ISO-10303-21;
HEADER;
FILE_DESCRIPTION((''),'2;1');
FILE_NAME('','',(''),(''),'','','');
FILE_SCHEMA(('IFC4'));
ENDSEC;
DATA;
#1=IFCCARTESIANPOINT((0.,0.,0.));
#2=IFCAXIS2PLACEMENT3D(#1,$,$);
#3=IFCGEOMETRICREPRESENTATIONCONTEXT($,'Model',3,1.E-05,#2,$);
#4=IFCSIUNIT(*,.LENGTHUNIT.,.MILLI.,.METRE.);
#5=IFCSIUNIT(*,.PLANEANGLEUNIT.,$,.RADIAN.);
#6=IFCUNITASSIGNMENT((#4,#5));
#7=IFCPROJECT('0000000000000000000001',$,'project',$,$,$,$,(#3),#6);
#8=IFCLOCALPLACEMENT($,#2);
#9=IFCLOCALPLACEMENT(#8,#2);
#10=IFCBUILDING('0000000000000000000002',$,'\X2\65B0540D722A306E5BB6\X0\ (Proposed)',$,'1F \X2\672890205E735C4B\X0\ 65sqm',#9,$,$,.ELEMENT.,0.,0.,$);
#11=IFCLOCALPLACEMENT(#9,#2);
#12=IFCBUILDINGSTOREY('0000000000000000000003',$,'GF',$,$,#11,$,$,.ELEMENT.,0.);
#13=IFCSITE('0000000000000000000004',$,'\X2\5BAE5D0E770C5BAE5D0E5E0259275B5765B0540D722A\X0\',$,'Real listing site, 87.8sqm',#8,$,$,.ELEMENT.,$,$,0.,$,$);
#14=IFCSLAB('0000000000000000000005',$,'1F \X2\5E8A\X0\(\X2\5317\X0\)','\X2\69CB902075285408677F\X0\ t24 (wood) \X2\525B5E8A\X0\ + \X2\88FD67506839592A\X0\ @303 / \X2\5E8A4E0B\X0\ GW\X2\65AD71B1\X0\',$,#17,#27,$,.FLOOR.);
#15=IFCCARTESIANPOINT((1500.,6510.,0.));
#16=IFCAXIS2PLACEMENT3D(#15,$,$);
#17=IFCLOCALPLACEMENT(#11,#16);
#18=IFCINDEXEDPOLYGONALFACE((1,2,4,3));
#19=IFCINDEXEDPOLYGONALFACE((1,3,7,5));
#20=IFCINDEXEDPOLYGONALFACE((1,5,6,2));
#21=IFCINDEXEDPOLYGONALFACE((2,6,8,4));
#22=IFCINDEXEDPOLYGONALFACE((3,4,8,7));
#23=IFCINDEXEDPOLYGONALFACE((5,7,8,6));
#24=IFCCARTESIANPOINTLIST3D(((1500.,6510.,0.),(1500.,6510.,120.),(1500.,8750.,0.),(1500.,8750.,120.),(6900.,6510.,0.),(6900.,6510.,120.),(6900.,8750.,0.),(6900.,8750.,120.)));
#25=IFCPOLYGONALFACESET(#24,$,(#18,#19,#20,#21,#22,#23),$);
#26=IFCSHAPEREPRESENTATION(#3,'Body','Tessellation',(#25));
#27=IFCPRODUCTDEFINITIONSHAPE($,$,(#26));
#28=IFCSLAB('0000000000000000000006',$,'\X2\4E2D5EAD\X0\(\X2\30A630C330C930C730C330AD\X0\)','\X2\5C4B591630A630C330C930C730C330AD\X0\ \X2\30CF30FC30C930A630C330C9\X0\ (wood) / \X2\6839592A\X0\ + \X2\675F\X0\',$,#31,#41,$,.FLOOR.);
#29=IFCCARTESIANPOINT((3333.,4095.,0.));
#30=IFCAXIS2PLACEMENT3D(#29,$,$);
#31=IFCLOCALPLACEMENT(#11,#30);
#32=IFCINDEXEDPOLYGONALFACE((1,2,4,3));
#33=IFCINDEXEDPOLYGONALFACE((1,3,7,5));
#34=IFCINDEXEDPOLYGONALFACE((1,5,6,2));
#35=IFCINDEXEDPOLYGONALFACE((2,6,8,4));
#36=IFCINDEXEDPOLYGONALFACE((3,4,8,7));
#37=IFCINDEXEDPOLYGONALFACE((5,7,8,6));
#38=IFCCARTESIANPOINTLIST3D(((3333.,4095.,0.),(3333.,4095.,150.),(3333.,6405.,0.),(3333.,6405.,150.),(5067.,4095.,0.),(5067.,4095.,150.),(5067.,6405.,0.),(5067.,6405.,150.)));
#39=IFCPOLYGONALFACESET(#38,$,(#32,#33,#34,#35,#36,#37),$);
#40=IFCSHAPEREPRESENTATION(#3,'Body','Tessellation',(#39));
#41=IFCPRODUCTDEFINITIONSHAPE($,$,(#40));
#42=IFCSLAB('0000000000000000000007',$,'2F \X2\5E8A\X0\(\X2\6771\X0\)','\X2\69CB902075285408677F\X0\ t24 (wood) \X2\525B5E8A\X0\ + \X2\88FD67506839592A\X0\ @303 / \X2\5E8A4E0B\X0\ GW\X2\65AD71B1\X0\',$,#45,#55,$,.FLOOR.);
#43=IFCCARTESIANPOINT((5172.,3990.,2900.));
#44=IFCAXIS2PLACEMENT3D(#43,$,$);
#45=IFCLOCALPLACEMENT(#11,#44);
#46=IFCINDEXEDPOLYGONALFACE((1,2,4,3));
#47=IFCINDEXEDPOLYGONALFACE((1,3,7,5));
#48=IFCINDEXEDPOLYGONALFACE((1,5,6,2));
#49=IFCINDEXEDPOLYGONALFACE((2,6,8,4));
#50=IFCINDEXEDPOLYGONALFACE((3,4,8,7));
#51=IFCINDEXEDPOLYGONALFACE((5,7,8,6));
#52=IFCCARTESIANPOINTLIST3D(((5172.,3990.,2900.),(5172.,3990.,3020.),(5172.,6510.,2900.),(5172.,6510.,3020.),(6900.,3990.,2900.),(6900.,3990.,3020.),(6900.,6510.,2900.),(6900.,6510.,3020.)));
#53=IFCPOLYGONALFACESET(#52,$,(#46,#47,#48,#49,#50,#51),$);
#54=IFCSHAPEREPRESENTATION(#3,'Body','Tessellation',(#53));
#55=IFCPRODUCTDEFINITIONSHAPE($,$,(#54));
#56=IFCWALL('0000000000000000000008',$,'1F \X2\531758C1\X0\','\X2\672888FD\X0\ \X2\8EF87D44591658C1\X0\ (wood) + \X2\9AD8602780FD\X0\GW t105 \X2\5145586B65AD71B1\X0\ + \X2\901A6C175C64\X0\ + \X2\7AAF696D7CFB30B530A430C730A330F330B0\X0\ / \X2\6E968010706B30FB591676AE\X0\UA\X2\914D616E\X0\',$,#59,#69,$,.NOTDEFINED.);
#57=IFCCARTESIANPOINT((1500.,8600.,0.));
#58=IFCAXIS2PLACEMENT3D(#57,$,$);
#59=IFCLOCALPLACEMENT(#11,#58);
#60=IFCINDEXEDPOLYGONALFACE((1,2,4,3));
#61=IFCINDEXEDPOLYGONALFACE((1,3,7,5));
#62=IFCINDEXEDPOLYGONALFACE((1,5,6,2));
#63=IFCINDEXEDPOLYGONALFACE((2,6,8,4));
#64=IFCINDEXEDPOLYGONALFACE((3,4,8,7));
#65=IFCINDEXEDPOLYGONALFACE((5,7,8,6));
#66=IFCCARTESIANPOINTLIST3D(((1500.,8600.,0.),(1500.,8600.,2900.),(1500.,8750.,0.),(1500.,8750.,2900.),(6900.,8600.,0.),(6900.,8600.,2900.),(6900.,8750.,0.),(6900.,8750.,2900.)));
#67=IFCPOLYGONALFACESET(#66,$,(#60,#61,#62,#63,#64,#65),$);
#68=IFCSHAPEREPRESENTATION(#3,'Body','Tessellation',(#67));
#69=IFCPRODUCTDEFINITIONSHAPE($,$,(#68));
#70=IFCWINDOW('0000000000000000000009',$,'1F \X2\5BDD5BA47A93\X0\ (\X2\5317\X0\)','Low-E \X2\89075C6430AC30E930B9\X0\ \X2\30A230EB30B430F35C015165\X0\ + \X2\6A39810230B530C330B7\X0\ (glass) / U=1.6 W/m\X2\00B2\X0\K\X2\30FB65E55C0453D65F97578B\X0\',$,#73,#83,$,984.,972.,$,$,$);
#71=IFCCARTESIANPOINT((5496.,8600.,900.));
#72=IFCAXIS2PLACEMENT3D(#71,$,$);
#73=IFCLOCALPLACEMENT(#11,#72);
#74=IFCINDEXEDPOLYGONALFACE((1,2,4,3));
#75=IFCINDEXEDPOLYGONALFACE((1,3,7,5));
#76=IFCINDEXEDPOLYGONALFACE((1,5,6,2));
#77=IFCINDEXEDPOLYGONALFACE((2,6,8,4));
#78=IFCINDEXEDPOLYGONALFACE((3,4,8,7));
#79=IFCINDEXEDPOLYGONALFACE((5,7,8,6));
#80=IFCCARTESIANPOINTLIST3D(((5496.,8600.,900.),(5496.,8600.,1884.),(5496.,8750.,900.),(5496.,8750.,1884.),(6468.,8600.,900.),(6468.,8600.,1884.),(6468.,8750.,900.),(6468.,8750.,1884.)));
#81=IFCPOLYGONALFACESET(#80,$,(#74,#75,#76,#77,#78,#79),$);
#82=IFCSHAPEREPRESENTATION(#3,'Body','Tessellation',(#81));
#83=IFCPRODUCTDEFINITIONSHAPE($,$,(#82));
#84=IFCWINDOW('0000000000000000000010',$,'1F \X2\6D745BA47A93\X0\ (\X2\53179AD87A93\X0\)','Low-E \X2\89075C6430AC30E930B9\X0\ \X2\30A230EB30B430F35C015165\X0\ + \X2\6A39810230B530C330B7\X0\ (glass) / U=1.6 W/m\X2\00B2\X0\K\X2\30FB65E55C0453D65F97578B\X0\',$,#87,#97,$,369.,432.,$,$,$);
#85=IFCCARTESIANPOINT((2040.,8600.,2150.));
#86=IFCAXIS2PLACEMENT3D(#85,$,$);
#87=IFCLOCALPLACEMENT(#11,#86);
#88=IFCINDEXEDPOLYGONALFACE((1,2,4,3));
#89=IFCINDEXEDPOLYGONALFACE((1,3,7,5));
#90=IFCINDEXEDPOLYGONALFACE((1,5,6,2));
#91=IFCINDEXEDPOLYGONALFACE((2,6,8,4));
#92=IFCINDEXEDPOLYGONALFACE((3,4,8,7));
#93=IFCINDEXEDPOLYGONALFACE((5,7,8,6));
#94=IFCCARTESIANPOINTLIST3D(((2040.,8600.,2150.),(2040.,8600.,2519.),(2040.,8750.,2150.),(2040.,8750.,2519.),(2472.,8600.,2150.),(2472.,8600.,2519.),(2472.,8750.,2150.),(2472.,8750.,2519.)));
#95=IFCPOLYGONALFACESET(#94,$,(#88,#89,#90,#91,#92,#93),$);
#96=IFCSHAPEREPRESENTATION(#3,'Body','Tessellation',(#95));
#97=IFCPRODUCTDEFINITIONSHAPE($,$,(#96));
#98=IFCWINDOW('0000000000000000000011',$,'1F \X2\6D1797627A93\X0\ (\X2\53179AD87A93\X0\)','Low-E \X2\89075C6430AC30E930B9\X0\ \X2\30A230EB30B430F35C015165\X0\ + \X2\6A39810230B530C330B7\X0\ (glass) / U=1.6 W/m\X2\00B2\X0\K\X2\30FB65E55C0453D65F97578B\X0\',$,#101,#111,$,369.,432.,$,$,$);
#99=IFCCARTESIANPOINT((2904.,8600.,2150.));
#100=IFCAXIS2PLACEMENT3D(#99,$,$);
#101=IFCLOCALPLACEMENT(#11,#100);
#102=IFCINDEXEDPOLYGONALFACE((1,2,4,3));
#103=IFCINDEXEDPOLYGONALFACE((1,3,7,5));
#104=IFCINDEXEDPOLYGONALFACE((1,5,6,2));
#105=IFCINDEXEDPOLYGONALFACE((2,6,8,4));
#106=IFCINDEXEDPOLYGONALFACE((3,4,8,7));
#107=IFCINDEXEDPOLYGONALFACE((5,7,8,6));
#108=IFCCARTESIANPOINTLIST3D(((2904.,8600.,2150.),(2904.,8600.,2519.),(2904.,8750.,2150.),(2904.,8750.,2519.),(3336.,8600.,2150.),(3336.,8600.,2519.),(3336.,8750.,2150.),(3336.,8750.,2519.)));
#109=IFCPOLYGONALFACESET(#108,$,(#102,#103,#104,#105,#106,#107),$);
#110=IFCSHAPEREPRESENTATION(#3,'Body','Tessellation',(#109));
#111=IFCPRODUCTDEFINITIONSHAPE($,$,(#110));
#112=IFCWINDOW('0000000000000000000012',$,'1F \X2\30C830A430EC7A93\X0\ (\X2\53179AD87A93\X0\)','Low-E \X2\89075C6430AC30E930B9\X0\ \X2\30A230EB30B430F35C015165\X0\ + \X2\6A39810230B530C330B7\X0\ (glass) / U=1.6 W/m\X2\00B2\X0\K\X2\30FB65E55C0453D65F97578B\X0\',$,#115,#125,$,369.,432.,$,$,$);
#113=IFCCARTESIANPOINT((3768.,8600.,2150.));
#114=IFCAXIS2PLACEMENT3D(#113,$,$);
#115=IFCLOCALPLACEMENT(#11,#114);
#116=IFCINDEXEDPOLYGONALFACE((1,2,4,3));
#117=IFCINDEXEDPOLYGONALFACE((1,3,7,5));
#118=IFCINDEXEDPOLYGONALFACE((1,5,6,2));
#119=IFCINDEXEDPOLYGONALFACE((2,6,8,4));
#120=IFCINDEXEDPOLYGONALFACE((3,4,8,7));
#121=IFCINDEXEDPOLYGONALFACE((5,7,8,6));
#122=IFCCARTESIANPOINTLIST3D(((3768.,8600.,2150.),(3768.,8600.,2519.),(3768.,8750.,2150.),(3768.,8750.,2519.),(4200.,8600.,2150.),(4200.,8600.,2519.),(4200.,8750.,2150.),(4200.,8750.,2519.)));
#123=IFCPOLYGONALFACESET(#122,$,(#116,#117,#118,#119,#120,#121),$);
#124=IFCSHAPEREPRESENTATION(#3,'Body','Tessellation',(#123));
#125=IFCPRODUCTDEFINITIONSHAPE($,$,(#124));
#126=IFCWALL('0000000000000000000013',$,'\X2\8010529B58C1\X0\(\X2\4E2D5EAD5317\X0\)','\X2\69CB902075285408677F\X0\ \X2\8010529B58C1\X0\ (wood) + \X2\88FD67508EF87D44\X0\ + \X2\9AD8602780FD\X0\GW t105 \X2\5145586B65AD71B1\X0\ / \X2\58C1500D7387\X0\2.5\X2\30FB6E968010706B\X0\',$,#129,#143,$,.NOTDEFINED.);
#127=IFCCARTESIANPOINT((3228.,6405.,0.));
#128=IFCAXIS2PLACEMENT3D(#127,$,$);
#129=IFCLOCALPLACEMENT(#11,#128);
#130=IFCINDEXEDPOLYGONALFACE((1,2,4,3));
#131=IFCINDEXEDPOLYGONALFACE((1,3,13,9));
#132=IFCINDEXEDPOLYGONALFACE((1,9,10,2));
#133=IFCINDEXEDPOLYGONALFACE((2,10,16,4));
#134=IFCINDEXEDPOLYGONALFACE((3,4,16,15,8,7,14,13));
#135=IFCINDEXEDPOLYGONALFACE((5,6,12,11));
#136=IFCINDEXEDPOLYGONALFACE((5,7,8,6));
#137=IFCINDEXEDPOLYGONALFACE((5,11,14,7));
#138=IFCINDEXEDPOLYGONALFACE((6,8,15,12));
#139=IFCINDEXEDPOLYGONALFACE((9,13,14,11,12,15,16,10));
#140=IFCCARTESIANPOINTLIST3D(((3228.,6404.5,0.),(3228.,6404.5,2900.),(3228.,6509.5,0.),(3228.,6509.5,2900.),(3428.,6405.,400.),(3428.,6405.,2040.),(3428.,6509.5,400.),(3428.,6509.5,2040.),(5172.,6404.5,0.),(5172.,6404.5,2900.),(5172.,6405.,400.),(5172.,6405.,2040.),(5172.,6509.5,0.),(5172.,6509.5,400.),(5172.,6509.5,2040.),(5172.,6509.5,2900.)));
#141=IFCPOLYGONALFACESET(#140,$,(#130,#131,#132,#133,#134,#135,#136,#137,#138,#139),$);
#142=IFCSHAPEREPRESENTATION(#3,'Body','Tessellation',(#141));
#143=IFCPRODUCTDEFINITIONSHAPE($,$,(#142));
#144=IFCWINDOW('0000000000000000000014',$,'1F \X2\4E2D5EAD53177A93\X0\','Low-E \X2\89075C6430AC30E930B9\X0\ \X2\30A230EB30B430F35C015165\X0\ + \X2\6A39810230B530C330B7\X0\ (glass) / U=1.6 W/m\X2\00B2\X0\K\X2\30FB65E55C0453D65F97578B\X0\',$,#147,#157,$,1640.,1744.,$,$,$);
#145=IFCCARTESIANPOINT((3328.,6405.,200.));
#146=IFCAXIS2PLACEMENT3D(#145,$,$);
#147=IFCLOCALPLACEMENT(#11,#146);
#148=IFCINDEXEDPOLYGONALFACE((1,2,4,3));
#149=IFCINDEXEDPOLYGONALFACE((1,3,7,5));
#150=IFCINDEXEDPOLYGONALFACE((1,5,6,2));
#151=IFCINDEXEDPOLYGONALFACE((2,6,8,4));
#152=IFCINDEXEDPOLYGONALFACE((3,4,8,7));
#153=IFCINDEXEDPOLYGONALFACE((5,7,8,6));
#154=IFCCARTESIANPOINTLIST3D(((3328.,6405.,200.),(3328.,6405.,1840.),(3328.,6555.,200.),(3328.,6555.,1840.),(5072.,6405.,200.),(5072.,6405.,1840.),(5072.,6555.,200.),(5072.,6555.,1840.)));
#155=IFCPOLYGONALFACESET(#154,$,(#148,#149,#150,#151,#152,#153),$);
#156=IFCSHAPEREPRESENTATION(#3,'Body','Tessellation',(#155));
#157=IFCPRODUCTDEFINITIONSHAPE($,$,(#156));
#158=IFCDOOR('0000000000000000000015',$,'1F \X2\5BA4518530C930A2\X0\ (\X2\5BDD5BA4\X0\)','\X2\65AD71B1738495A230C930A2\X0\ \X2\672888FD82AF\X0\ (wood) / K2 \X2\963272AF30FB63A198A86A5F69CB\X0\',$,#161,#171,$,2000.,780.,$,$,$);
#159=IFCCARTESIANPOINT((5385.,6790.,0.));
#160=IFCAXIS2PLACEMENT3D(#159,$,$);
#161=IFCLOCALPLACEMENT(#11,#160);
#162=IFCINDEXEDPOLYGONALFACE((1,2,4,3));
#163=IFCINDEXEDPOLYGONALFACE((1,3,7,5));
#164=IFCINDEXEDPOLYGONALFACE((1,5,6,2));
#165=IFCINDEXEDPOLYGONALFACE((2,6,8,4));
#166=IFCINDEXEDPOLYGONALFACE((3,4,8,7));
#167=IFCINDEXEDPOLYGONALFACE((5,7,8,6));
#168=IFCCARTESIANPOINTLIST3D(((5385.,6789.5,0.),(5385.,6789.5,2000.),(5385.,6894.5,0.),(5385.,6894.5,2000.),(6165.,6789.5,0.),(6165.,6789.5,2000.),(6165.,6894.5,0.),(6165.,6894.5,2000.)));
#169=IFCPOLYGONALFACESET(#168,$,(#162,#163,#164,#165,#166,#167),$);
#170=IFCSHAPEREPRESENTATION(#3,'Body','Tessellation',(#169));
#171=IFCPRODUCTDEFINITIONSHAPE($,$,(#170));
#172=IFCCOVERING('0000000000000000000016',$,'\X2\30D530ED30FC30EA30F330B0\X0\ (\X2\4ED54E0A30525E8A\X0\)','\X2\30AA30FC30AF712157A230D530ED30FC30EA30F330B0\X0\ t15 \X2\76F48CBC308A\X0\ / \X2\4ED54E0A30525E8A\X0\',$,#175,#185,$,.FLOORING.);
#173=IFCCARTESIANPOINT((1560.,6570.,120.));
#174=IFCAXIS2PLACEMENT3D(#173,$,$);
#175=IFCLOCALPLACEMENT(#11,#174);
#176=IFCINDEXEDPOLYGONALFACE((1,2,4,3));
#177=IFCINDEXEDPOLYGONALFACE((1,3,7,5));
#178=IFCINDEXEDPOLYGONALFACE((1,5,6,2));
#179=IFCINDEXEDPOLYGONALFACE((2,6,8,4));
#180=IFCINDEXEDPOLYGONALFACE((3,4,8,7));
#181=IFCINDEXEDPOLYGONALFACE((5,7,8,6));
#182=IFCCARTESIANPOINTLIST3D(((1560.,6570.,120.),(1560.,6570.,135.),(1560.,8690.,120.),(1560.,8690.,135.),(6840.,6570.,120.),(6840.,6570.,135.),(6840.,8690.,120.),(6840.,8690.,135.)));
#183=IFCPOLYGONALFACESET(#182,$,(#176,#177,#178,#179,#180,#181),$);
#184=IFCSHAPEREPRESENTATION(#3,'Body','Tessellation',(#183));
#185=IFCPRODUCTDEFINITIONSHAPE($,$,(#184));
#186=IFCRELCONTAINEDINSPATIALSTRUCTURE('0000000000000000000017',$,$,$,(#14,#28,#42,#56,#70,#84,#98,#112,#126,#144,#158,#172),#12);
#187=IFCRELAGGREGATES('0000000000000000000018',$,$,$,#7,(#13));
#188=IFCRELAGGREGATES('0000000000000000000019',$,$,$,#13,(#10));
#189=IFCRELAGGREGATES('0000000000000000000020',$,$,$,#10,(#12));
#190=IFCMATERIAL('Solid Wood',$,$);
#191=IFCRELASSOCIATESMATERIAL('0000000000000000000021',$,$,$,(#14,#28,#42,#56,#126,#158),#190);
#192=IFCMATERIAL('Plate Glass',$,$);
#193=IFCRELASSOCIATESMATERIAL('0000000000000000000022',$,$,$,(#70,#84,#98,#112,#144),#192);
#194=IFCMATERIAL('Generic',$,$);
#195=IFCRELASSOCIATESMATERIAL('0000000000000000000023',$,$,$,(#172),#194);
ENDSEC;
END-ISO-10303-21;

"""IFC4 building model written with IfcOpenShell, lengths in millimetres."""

from ifc_helpers import new_model, si_unit, frame, frame_2d, origin, place, context, project, spatial, rectangle, extrude, material, element, fill, save


model = new_model("IFC4")

# Units and contexts
model_context = context("Model", 3, precision=1e-05, world=origin())
ifc_project = project(units=[si_unit("LENGTHUNIT", "METRE", prefix="MILLI"), si_unit("PLANEANGLEUNIT", "RADIAN")], contexts=[model_context])

# Site, building, storey
site_placement = place(None, origin())
site = spatial("IfcSite", under=ifc_project, at=site_placement, Name="宮崎県宮崎市大字新名爪", ObjectType="Real listing site, 87.8sqm", CompositionType="ELEMENT", RefElevation=0.0)
building_placement = place(site_placement, origin())
building = spatial("IfcBuilding", under=site, at=building_placement, Name="新名爪の家 (Proposed)", ObjectType="1F 木造平屋 65sqm", CompositionType="ELEMENT", ElevationOfRefHeight=0.0, ElevationOfTerrain=0.0)
storey_placement = place(building_placement, origin())
storey = spatial("IfcBuildingStorey", under=building, at=storey_placement, Name="GF", CompositionType="ELEMENT", Elevation=0.0)

# Slabs
ifc_material_1 = material(Name="Solid Wood")
slab_1_placement = place(storey_placement, frame((1500.0, 6510.0, 0.0)))
element("IfcSlab", 1, at=slab_1_placement, inside=storey, material=ifc_material_1, Name="1F 床(北)", Description="構造用合板 t24 (wood) 剛床 + 製材根太 @303 / 床下 GW断熱", PredefinedType="FLOOR", context=model_context, shape_type="SweptSolid", body=[
    extrude(rectangle(XDim=5400.0, YDim=2240.0, at=frame_2d((2700.0, 1120.0))), frame((1500.0, 6510.0, 0.0)), (0.0, 0.0, 1.0), 120.0),
])
slab_2_placement = place(storey_placement, frame((3333.0, 4095.0, 0.0)))
element("IfcSlab", 2, at=slab_2_placement, inside=storey, material=ifc_material_1, Name="中庭(ウッドデッキ)", Description="屋外ウッドデッキ ハードウッド (wood) / 根太 + 束", PredefinedType="FLOOR", context=model_context, shape_type="SweptSolid", body=[
    extrude(rectangle(XDim=1734.0, YDim=2310.0, at=frame_2d((867.0, 1155.0))), frame((3333.0, 4095.0, 0.0)), (0.0, 0.0, 1.0), 150.0),
])
slab_3_placement = place(storey_placement, frame((5172.0, 3990.0, 2900.0)))
element("IfcSlab", 3, at=slab_3_placement, inside=storey, material=ifc_material_1, Name="2F 床(東)", Description="構造用合板 t24 (wood) 剛床 + 製材根太 @303 / 床下 GW断熱", PredefinedType="FLOOR", context=model_context, shape_type="SweptSolid", body=[
    extrude(rectangle(XDim=1728.0, YDim=2520.0, at=frame_2d((864.0, 1260.0))), frame((5172.0, 3990.0, 2900.0)), (0.0, 0.0, 1.0), 120.0),
])

# Wall, openings, windows
wall_1_placement = place(storey_placement, frame((1500.0, 8600.0, 0.0)))
wall_1 = element("IfcWall", 4, at=wall_1_placement, inside=storey, material=ifc_material_1, Name="1F 北壁", Description="木製 軸組外壁 (wood) + 高性能GW t105 充填断熱 + 通気層 + 窯業系サイディング / 準耐火・外皮UA配慮", PredefinedType="NOTDEFINED", context=model_context, shape_type="SweptSolid", body=[
    extrude(rectangle(XDim=5400.0, YDim=150.0, at=frame_2d((2700.0, 75.0))), frame((1500.0, 8600.0, 0.0)), (0.0, 0.0, 1.0), 2900.0),
])
opening_1_placement = place(storey_placement, frame((5496.0, 8600.0, 900.0)))
opening_1 = element("IfcOpeningElement", 5, at=opening_1_placement, cuts=wall_1, PredefinedType="NOTDEFINED", context=model_context, shape_type="SweptSolid", body=[
    extrude(rectangle(XDim=972.0, YDim=150.0, at=frame_2d((486.0, 75.0))), frame((5496.0, 8600.0, 900.0)), (0.0, 0.0, 1.0), 984.0),
])
opening_2_placement = place(storey_placement, frame((2040.0, 8600.0, 2150.0)))
opening_2 = element("IfcOpeningElement", 6, at=opening_2_placement, cuts=wall_1, PredefinedType="NOTDEFINED", context=model_context, shape_type="SweptSolid", body=[
    extrude(rectangle(XDim=432.0, YDim=150.0, at=frame_2d((216.0, 75.0))), frame((2040.0, 8600.0, 2150.0)), (0.0, 0.0, 1.0), 369.0),
])
opening_3_placement = place(storey_placement, frame((2904.0, 8600.0, 2150.0)))
opening_3 = element("IfcOpeningElement", 7, at=opening_3_placement, cuts=wall_1, PredefinedType="NOTDEFINED", context=model_context, shape_type="SweptSolid", body=[
    extrude(rectangle(XDim=432.0, YDim=150.0, at=frame_2d((216.0, 75.0))), frame((2904.0, 8600.0, 2150.0)), (0.0, 0.0, 1.0), 369.0),
])
opening_4_placement = place(storey_placement, frame((3768.0, 8600.0, 2150.0)))
opening_4 = element("IfcOpeningElement", 8, at=opening_4_placement, cuts=wall_1, PredefinedType="NOTDEFINED", context=model_context, shape_type="SweptSolid", body=[
    extrude(rectangle(XDim=432.0, YDim=150.0, at=frame_2d((216.0, 75.0))), frame((3768.0, 8600.0, 2150.0)), (0.0, 0.0, 1.0), 369.0),
])
ifc_material_2 = material(Name="Plate Glass")
window_1_placement = place(storey_placement, frame((5496.0, 8600.0, 900.0)))
window_1 = element("IfcWindow", 9, at=window_1_placement, inside=storey, material=ifc_material_2, Name="1F 寝室窓 (北)", Description="Low-E 複層ガラス アルゴン封入 + 樹脂サッシ (glass) / U=1.6 W/m²K・日射取得型", OverallHeight=984.0, OverallWidth=972.0, context=model_context, shape_type="SweptSolid", body=[
    extrude(rectangle(XDim=972.0, YDim=150.0, at=frame_2d((486.0, 75.0))), frame((5496.0, 8600.0, 900.0)), (0.0, 0.0, 1.0), 984.0),
])
fill(opening_1, window_1)
window_2_placement = place(storey_placement, frame((2040.0, 8600.0, 2150.0)))
window_2 = element("IfcWindow", 10, at=window_2_placement, inside=storey, material=ifc_material_2, Name="1F 浴室窓 (北高窓)", Description="Low-E 複層ガラス アルゴン封入 + 樹脂サッシ (glass) / U=1.6 W/m²K・日射取得型", OverallHeight=369.0, OverallWidth=432.0, context=model_context, shape_type="SweptSolid", body=[
    extrude(rectangle(XDim=432.0, YDim=150.0, at=frame_2d((216.0, 75.0))), frame((2040.0, 8600.0, 2150.0)), (0.0, 0.0, 1.0), 369.0),
])
fill(opening_2, window_2)
window_3_placement = place(storey_placement, frame((2904.0, 8600.0, 2150.0)))
window_3 = element("IfcWindow", 11, at=window_3_placement, inside=storey, material=ifc_material_2, Name="1F 洗面窓 (北高窓)", Description="Low-E 複層ガラス アルゴン封入 + 樹脂サッシ (glass) / U=1.6 W/m²K・日射取得型", OverallHeight=369.0, OverallWidth=432.0, context=model_context, shape_type="SweptSolid", body=[
    extrude(rectangle(XDim=432.0, YDim=150.0, at=frame_2d((216.0, 75.0))), frame((2904.0, 8600.0, 2150.0)), (0.0, 0.0, 1.0), 369.0),
])
fill(opening_3, window_3)
window_4_placement = place(storey_placement, frame((3768.0, 8600.0, 2150.0)))
window_4 = element("IfcWindow", 12, at=window_4_placement, inside=storey, material=ifc_material_2, Name="1F トイレ窓 (北高窓)", Description="Low-E 複層ガラス アルゴン封入 + 樹脂サッシ (glass) / U=1.6 W/m²K・日射取得型", OverallHeight=369.0, OverallWidth=432.0, context=model_context, shape_type="SweptSolid", body=[
    extrude(rectangle(XDim=432.0, YDim=150.0, at=frame_2d((216.0, 75.0))), frame((3768.0, 8600.0, 2150.0)), (0.0, 0.0, 1.0), 369.0),
])
fill(opening_4, window_4)

# Wall, opening, window
wall_2_placement = place(storey_placement, frame((3228.0, 6405.0, 0.0)))
wall_2 = element("IfcWall", 13, at=wall_2_placement, inside=storey, material=ifc_material_1, Name="耐力壁(中庭北)", Description="構造用合板 耐力壁 (wood) + 製材軸組 + 高性能GW t105 充填断熱 / 壁倍率2.5・準耐火", PredefinedType="NOTDEFINED", context=model_context, shape_type="SweptSolid", body=[
    extrude(rectangle(XDim=1944.0, YDim=105.0, at=frame_2d((972.0, 52.0))), frame((3228.0, 6405.0, 0.0)), (0.0, 0.0, 1.0), 2900.0),
])
opening_5_placement = place(storey_placement, frame((3328.0, 6405.0, 200.0)))
opening_5 = element("IfcOpeningElement", 14, at=opening_5_placement, cuts=wall_2, PredefinedType="NOTDEFINED", context=model_context, shape_type="SweptSolid", body=[
    extrude(rectangle(XDim=1744.0, YDim=150.0, at=frame_2d((872.0, 75.0))), frame((3328.0, 6405.0, 200.0)), (0.0, 0.0, 1.0), 1640.0),
])
window_5_placement = place(storey_placement, frame((3328.0, 6405.0, 200.0)))
window_5 = element("IfcWindow", 15, at=window_5_placement, inside=storey, material=ifc_material_2, Name="1F 中庭北窓", Description="Low-E 複層ガラス アルゴン封入 + 樹脂サッシ (glass) / U=1.6 W/m²K・日射取得型", OverallHeight=1640.0, OverallWidth=1744.0, context=model_context, shape_type="SweptSolid", body=[
    extrude(rectangle(XDim=1744.0, YDim=150.0, at=frame_2d((872.0, 75.0))), frame((3328.0, 6405.0, 200.0)), (0.0, 0.0, 1.0), 1640.0),
])
fill(opening_5, window_5)

# Door
door_1_placement = place(storey_placement, frame((5385.0, 6790.0, 0.0)))
element("IfcDoor", 16, at=door_1_placement, inside=storey, material=ifc_material_1, Name="1F 室内ドア (寝室)", Description="断熱玄関ドア 木製芯 (wood) / K2 防犯・採風機構", OverallHeight=2000.0, OverallWidth=780.0, context=model_context, shape_type="SweptSolid", body=[
    extrude(rectangle(XDim=780.0, YDim=105.0, at=frame_2d((390.0, 52.0))), frame((5385.0, 6790.0, 0.0)), (0.0, 0.0, 1.0), 2000.0),
])

# Covering
ifc_material_3 = material(Name="Generic")
covering_1_placement = place(storey_placement, frame((1560.0, 6570.0, 120.0)))
element("IfcCovering", 17, at=covering_1_placement, inside=storey, material=ifc_material_3, Name="フローリング (仕上げ床)", Description="オーク無垢フローリング t15 直貼り / 仕上げ床", PredefinedType="FLOORING", context=model_context, shape_type="SweptSolid", body=[
    extrude(rectangle(XDim=5280.0, YDim=2120.0, at=frame_2d((2640.0, 1060.0))), frame((1560.0, 6570.0, 120.0)), (0.0, 0.0, 1.0), 15.0),
])

save(model, "model.ifc")
